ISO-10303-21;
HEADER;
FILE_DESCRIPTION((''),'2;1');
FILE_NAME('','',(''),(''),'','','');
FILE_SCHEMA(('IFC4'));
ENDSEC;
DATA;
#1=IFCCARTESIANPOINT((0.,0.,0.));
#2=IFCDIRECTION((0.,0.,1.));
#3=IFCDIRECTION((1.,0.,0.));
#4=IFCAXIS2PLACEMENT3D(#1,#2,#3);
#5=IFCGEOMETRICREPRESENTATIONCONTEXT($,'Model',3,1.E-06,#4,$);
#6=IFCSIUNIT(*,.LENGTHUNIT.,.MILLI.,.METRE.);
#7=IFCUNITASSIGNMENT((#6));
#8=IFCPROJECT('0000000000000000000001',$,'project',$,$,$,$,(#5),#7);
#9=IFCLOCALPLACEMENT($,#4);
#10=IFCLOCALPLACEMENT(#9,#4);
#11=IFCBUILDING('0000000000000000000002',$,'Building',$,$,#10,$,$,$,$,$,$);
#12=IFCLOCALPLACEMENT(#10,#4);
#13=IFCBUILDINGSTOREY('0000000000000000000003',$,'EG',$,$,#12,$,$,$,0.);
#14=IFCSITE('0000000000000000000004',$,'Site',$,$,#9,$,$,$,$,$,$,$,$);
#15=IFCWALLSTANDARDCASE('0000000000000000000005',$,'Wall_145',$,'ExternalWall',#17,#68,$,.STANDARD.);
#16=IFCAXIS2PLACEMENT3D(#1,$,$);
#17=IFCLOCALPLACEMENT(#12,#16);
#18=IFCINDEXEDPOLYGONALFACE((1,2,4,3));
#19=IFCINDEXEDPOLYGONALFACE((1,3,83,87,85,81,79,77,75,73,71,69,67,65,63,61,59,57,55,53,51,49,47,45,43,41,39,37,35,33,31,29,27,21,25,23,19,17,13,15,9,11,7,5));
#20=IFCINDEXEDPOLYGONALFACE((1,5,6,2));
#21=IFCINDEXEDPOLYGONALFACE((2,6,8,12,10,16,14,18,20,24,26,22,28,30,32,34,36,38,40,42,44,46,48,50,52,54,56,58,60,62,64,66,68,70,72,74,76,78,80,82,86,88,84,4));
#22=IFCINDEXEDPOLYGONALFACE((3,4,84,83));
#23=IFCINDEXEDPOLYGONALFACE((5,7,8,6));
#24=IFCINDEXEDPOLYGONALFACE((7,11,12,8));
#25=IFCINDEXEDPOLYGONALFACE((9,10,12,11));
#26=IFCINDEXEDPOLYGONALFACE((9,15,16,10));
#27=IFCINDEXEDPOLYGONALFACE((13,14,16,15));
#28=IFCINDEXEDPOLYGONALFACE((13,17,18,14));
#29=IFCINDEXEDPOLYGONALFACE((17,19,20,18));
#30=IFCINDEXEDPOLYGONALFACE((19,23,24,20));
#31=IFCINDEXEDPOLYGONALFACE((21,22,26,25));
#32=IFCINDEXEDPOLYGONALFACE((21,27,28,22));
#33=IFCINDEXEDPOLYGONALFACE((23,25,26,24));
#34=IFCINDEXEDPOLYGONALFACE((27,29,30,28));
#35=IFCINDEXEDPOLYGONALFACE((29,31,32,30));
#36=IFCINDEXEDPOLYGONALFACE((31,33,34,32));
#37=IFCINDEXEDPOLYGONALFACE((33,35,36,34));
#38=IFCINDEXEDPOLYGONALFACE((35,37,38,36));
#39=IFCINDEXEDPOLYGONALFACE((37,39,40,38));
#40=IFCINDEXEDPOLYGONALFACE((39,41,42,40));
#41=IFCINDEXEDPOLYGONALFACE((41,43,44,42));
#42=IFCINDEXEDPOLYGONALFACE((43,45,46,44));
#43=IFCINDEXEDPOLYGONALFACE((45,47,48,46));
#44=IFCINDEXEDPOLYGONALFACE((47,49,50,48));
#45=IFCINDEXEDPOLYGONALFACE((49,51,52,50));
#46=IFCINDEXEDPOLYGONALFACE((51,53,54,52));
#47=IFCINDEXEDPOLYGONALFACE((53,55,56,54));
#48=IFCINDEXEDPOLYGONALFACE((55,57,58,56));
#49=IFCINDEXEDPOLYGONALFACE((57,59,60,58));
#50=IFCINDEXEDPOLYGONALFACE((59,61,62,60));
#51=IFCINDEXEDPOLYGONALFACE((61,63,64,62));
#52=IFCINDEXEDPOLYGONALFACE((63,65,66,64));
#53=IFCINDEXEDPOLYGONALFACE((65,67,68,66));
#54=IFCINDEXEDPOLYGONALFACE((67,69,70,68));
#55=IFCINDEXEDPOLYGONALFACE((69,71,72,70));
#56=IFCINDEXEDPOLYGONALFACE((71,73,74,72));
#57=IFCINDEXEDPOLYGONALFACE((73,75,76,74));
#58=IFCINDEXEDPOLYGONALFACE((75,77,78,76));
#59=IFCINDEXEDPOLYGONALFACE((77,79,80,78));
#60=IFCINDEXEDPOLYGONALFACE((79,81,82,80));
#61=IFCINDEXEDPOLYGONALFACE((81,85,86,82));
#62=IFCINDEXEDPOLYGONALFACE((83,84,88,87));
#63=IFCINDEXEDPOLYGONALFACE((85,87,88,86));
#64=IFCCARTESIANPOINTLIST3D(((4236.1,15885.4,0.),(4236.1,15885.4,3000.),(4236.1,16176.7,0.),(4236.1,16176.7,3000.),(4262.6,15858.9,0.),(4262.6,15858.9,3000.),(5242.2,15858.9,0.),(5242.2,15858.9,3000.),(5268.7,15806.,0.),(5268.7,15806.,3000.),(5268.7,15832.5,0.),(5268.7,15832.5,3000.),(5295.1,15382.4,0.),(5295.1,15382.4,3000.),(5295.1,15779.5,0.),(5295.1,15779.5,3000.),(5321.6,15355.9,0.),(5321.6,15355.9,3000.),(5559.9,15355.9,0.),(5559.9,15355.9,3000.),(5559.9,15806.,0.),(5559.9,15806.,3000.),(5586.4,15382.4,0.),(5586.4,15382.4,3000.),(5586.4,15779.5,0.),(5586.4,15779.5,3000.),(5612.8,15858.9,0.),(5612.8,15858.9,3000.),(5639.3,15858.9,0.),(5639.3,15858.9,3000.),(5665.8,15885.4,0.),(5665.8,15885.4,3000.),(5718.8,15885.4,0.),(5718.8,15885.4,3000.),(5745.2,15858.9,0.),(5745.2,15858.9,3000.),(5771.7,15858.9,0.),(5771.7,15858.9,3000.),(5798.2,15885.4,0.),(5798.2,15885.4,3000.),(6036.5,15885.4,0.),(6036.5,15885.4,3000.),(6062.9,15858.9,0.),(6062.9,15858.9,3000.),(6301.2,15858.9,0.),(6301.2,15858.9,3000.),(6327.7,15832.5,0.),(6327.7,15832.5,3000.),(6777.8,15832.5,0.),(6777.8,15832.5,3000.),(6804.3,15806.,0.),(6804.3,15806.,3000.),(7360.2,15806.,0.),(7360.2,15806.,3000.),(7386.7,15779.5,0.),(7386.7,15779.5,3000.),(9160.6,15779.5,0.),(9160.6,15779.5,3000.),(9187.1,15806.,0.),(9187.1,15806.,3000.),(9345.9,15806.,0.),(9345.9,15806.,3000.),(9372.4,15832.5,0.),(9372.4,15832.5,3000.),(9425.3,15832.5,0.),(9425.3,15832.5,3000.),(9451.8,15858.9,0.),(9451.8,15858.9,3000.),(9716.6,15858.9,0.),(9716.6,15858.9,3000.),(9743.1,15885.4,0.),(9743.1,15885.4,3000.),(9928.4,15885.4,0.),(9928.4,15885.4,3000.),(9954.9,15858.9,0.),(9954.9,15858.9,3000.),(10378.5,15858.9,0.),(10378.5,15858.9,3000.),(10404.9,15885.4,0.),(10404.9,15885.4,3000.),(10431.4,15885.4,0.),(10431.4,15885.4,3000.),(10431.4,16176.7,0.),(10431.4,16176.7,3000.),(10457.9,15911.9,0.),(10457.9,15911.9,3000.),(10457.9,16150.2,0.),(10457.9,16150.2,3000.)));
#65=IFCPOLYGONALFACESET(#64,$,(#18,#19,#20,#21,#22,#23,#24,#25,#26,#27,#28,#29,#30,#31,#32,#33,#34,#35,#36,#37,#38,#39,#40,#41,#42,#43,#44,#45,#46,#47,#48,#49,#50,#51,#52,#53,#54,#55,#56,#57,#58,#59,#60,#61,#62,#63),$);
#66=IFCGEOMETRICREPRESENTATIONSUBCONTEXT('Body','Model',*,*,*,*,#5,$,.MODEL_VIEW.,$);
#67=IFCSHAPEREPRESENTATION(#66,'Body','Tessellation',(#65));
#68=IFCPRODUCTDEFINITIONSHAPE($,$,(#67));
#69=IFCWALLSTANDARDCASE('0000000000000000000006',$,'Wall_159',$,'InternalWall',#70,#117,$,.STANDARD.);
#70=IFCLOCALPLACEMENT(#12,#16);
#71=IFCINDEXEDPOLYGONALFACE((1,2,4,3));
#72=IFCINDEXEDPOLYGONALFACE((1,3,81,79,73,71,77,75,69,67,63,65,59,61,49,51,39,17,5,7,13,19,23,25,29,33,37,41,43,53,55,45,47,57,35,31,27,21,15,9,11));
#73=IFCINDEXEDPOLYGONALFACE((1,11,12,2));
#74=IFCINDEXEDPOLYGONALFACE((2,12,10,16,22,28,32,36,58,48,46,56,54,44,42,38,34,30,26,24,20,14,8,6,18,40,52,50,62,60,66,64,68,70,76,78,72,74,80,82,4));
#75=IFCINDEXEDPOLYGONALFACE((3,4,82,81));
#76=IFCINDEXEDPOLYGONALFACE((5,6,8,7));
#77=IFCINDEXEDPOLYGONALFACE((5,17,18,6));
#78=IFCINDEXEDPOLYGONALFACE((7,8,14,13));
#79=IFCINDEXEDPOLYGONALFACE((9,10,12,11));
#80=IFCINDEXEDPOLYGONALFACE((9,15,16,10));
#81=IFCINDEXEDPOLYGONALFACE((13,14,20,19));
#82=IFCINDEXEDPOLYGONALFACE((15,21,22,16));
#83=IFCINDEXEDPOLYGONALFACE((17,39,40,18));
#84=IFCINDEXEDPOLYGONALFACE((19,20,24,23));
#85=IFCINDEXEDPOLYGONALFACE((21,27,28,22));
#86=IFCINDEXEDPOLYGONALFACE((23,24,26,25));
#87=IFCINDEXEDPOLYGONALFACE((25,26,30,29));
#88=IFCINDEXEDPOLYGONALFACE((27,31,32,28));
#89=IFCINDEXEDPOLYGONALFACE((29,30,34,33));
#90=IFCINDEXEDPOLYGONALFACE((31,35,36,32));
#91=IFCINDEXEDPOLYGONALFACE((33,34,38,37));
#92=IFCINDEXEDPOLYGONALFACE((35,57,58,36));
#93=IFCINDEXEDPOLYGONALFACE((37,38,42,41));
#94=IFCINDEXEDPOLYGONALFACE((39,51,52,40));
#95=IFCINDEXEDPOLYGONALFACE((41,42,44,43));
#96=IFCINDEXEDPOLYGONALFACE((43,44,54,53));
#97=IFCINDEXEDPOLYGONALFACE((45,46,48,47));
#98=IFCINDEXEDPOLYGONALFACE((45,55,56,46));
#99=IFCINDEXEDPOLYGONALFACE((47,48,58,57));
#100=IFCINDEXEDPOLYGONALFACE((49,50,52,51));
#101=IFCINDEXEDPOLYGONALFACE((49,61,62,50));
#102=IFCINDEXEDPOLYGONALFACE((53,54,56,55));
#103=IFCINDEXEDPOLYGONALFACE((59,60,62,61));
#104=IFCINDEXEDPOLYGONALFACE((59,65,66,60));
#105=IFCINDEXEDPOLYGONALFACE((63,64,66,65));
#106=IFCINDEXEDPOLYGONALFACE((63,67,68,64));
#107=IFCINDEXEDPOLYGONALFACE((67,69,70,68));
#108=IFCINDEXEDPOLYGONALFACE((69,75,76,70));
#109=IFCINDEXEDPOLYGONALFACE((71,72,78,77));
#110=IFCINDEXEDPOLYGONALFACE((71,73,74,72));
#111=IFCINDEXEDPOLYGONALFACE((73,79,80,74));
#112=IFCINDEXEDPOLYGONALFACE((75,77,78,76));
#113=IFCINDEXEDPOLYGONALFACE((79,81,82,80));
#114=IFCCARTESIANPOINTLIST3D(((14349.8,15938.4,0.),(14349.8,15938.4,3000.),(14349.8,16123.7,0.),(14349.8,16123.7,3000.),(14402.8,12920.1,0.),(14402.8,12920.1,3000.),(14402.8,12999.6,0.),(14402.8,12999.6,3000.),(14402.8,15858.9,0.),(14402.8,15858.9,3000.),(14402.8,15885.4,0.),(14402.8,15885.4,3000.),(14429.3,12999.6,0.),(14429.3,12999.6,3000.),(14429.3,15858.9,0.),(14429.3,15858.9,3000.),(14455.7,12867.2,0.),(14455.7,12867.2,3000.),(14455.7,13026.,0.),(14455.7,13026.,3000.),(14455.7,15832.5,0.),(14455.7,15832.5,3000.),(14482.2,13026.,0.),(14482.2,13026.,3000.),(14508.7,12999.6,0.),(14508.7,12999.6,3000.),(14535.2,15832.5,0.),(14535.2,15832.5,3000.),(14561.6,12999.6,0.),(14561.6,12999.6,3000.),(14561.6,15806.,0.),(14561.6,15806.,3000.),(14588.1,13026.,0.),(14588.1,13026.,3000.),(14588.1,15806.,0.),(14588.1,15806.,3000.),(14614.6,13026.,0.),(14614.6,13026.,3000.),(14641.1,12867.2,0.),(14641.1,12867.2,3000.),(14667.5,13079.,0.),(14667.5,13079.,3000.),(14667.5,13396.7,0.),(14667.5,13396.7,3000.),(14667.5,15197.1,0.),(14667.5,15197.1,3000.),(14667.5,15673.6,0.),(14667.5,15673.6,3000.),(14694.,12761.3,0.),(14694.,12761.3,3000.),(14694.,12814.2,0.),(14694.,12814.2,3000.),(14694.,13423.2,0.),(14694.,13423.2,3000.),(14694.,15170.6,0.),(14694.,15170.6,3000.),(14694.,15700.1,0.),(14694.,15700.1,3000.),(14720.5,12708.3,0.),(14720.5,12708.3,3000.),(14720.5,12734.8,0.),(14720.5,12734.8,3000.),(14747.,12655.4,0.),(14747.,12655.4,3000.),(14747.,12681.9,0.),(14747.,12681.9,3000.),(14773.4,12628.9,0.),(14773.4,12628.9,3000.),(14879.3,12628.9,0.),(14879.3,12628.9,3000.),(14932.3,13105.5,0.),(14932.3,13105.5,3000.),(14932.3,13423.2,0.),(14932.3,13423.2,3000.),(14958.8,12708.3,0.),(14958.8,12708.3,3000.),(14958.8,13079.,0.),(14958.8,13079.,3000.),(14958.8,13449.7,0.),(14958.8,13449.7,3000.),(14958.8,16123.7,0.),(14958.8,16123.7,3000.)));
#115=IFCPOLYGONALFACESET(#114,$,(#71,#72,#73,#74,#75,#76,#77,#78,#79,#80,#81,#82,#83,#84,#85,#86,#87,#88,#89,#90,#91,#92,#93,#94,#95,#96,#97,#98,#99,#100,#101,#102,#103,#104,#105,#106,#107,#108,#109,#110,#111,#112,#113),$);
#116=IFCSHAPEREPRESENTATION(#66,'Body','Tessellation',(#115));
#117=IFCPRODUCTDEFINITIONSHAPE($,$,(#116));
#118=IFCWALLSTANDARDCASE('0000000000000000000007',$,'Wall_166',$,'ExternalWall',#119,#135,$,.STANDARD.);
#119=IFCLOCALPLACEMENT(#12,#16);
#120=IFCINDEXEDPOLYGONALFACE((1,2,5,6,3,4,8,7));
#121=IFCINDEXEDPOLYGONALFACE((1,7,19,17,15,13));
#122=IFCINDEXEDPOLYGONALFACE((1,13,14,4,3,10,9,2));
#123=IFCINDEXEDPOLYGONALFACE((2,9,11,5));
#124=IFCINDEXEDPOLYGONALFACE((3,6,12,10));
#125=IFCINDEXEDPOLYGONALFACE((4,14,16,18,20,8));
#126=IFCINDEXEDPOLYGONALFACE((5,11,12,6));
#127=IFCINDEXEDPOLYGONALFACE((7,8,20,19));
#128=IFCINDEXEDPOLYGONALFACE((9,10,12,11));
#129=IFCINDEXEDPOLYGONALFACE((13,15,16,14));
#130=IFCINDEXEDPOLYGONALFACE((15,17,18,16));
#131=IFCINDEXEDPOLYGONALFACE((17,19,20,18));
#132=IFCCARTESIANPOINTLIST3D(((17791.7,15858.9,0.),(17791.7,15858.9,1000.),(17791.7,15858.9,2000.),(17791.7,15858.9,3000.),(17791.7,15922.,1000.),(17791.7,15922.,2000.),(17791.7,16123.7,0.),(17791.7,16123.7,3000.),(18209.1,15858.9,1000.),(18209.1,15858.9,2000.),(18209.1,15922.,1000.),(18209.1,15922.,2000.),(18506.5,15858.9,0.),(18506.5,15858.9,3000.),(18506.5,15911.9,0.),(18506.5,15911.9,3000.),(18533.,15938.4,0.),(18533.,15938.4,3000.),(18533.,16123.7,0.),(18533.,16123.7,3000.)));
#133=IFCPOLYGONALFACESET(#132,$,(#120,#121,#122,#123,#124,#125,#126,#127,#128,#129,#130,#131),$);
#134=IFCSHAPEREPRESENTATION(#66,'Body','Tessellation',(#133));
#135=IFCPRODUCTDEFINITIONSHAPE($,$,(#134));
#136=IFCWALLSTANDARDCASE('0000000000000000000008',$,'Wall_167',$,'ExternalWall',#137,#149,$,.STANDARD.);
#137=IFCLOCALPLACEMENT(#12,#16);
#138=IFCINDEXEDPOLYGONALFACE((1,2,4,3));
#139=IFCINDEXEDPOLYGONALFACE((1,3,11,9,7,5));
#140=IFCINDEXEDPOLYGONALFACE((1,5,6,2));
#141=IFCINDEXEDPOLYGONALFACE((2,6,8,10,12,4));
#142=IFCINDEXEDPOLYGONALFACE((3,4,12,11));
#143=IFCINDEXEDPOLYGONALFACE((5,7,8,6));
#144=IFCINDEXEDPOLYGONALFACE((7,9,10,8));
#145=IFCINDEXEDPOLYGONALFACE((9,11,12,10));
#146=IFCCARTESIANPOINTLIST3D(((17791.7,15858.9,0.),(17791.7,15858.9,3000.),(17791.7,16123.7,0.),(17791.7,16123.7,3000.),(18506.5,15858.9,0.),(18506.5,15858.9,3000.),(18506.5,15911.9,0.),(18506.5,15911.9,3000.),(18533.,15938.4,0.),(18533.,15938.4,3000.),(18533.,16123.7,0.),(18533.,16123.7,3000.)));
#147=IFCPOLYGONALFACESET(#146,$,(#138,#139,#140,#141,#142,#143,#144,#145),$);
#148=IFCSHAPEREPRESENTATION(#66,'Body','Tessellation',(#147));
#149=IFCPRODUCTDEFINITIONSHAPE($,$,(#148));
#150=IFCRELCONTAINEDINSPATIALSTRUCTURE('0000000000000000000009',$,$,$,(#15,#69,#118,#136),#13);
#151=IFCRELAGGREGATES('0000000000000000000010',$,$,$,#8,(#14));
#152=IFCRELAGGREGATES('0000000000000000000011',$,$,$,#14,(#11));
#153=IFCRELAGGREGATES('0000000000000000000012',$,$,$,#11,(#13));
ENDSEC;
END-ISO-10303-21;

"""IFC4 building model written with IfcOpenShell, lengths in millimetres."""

from ifc_helpers import new_model, si_unit, frame, origin_with_axes, place, context, subcontext, project, spatial, polyline, rectangle, outline, extrude, element, save


model = new_model("IFC4")

# Units and contexts
model_context = context("Model", 3, precision=1e-06, world=origin_with_axes())
body_context = subcontext(model_context, "Body", "Model", "MODEL_VIEW")
ifc_project = project(units=[si_unit("LENGTHUNIT", "METRE", prefix="MILLI")], contexts=[model_context])

# Site, building, storey
site_placement = place(None, origin_with_axes())
site = spatial("IfcSite", under=ifc_project, at=site_placement, Name="Site")
building_placement = place(site_placement, origin_with_axes())
building = spatial("IfcBuilding", under=site, at=building_placement, Name="Building")
storey_placement = place(building_placement, origin_with_axes())
storey = spatial("IfcBuildingStorey", under=building, at=storey_placement, Name="EG", Elevation=0.0)

# Walls
wall_1_placement = place(storey_placement, origin_with_axes())
element("IfcWallStandardCase", 1, at=wall_1_placement, inside=storey, Name="Wall_145", ObjectType="ExternalWall", PredefinedType="STANDARD", context=body_context, shape_type="SweptSolid", body=[
    extrude(outline(polyline([(5321.6, 15355.9, 0.0), (5295.1, 15382.4, 0.0), (5295.1, 15779.5, 0.0), (5268.7, 15806.0, 0.0), (5268.7, 15832.5, 0.0), (5242.2, 15858.9, 0.0), (4262.6, 15858.9, 0.0), (4236.1, 15885.4, 0.0), (4236.1, 16176.7, 0.0), (10431.4, 16176.7, 0.0), (10457.9, 16150.2, 0.0), (10457.9, 15911.9, 0.0), (10431.4, 15885.4, 0.0), (10404.9, 15885.4, 0.0), (10378.5, 15858.9, 0.0), (9954.9, 15858.9, 0.0), (9928.4, 15885.4, 0.0), (9743.1, 15885.4, 0.0), (9716.6, 15858.9, 0.0), (9451.8, 15858.9, 0.0), (9425.3, 15832.5, 0.0), (9372.4, 15832.5, 0.0), (9345.9, 15806.0, 0.0), (9187.1, 15806.0, 0.0), (9160.6, 15779.5, 0.0), (7386.7, 15779.5, 0.0), (7360.2, 15806.0, 0.0), (6804.3, 15806.0, 0.0), (6777.8, 15832.5, 0.0), (6327.7, 15832.5, 0.0), (6301.2, 15858.9, 0.0), (6062.9, 15858.9, 0.0), (6036.5, 15885.4, 0.0), (5798.2, 15885.4, 0.0), (5771.7, 15858.9, 0.0), (5745.2, 15858.9, 0.0), (5718.8, 15885.4, 0.0), (5665.8, 15885.4, 0.0), (5639.3, 15858.9, 0.0), (5612.8, 15858.9, 0.0), (5559.9, 15806.0, 0.0), (5586.4, 15779.5, 0.0), (5586.4, 15382.4, 0.0), (5559.9, 15355.9, 0.0), (5321.6, 15355.9, 0.0)])), origin_with_axes(), (0.0, 0.0, 1.0), 3000.0),
])
wall_2_placement = place(storey_placement, origin_with_axes())
element("IfcWallStandardCase", 2, at=wall_2_placement, inside=storey, Name="Wall_159", ObjectType="InternalWall", PredefinedType="STANDARD", context=body_context, shape_type="SweptSolid", body=[
    extrude(outline(polyline([(14773.4, 12628.9, 0.0), (14747.0, 12655.4, 0.0), (14747.0, 12681.9, 0.0), (14720.5, 12708.3, 0.0), (14720.5, 12734.8, 0.0), (14694.0, 12761.3, 0.0), (14694.0, 12814.2, 0.0), (14641.1, 12867.2, 0.0), (14455.7, 12867.2, 0.0), (14402.8, 12920.1, 0.0), (14402.8, 12999.6, 0.0), (14429.3, 12999.6, 0.0), (14455.7, 13026.0, 0.0), (14482.2, 13026.0, 0.0), (14508.7, 12999.6, 0.0), (14561.6, 12999.6, 0.0), (14588.1, 13026.0, 0.0), (14614.6, 13026.0, 0.0), (14667.5, 13079.0, 0.0), (14667.5, 13396.7, 0.0), (14694.0, 13423.2, 0.0), (14694.0, 15170.6, 0.0), (14667.5, 15197.1, 0.0), (14667.5, 15673.6, 0.0), (14694.0, 15700.1, 0.0), (14588.1, 15806.0, 0.0), (14561.6, 15806.0, 0.0), (14535.2, 15832.5, 0.0), (14455.7, 15832.5, 0.0), (14429.3, 15858.9, 0.0), (14402.8, 15858.9, 0.0), (14402.8, 15885.4, 0.0), (14349.8, 15938.4, 0.0), (14349.8, 16123.7, 0.0), (14958.8, 16123.7, 0.0), (14958.8, 13449.7, 0.0), (14932.3, 13423.2, 0.0), (14932.3, 13105.5, 0.0), (14958.8, 13079.0, 0.0), (14958.8, 12708.3, 0.0), (14879.3, 12628.9, 0.0), (14773.4, 12628.9, 0.0)])), origin_with_axes(), (0.0, 0.0, 1.0), 3000.0),
])

# Wall, opening
wall_3_placement = place(storey_placement, origin_with_axes())
wall_3 = element("IfcWallStandardCase", 3, at=wall_3_placement, inside=storey, Name="Wall_166", ObjectType="ExternalWall", PredefinedType="STANDARD", context=body_context, shape_type="SweptSolid", body=[
    extrude(outline(polyline([(17791.7, 15858.9, 0.0), (17791.7, 16123.7, 0.0), (18533.0, 16123.7, 0.0), (18533.0, 15938.4, 0.0), (18506.5, 15911.9, 0.0), (18506.5, 15858.9, 0.0), (17791.7, 15858.9, 0.0)])), origin_with_axes(), (0.0, 0.0, 1.0), 3000.0),
])
opening_placement = place(wall_3_placement, origin_with_axes())
element("IfcOpeningElement", 4, at=opening_placement, inside=storey, cuts=wall_3, context=body_context, shape_type="SweptSolid", body=[
    extrude(rectangle(XDim=823.7, YDim=115.0), frame((17797.2, 15864.5, 1000.0), z_axis=(0.0, 0.0, 1.0), x_axis=(1.0, 0.0, 0.0)), (0.0, 0.0, 1.0), 1000.0),
])

# Wall
for number, where, z_axis, x_axis, name in (
    (5, (0.0, 0.0, 0.0), (0.0, 0.0, 1.0), (1.0, 0.0, 0.0), "Wall_167"),
):
    element("IfcWallStandardCase", number, at=place(storey_placement, frame(where, z_axis=z_axis, x_axis=x_axis)), inside=storey, Name=name, ObjectType="ExternalWall", PredefinedType="STANDARD", context=body_context, shape_type="SweptSolid", body=[
        extrude(outline(polyline([(17791.7, 15858.9, 0.0), (17791.7, 16123.7, 0.0), (18533.0, 16123.7, 0.0), (18533.0, 15938.4, 0.0), (18506.5, 15911.9, 0.0), (18506.5, 15858.9, 0.0), (17791.7, 15858.9, 0.0)])), origin_with_axes(), (0.0, 0.0, 1.0), 3000.0),
    ])

save(model, "model.ifc")
